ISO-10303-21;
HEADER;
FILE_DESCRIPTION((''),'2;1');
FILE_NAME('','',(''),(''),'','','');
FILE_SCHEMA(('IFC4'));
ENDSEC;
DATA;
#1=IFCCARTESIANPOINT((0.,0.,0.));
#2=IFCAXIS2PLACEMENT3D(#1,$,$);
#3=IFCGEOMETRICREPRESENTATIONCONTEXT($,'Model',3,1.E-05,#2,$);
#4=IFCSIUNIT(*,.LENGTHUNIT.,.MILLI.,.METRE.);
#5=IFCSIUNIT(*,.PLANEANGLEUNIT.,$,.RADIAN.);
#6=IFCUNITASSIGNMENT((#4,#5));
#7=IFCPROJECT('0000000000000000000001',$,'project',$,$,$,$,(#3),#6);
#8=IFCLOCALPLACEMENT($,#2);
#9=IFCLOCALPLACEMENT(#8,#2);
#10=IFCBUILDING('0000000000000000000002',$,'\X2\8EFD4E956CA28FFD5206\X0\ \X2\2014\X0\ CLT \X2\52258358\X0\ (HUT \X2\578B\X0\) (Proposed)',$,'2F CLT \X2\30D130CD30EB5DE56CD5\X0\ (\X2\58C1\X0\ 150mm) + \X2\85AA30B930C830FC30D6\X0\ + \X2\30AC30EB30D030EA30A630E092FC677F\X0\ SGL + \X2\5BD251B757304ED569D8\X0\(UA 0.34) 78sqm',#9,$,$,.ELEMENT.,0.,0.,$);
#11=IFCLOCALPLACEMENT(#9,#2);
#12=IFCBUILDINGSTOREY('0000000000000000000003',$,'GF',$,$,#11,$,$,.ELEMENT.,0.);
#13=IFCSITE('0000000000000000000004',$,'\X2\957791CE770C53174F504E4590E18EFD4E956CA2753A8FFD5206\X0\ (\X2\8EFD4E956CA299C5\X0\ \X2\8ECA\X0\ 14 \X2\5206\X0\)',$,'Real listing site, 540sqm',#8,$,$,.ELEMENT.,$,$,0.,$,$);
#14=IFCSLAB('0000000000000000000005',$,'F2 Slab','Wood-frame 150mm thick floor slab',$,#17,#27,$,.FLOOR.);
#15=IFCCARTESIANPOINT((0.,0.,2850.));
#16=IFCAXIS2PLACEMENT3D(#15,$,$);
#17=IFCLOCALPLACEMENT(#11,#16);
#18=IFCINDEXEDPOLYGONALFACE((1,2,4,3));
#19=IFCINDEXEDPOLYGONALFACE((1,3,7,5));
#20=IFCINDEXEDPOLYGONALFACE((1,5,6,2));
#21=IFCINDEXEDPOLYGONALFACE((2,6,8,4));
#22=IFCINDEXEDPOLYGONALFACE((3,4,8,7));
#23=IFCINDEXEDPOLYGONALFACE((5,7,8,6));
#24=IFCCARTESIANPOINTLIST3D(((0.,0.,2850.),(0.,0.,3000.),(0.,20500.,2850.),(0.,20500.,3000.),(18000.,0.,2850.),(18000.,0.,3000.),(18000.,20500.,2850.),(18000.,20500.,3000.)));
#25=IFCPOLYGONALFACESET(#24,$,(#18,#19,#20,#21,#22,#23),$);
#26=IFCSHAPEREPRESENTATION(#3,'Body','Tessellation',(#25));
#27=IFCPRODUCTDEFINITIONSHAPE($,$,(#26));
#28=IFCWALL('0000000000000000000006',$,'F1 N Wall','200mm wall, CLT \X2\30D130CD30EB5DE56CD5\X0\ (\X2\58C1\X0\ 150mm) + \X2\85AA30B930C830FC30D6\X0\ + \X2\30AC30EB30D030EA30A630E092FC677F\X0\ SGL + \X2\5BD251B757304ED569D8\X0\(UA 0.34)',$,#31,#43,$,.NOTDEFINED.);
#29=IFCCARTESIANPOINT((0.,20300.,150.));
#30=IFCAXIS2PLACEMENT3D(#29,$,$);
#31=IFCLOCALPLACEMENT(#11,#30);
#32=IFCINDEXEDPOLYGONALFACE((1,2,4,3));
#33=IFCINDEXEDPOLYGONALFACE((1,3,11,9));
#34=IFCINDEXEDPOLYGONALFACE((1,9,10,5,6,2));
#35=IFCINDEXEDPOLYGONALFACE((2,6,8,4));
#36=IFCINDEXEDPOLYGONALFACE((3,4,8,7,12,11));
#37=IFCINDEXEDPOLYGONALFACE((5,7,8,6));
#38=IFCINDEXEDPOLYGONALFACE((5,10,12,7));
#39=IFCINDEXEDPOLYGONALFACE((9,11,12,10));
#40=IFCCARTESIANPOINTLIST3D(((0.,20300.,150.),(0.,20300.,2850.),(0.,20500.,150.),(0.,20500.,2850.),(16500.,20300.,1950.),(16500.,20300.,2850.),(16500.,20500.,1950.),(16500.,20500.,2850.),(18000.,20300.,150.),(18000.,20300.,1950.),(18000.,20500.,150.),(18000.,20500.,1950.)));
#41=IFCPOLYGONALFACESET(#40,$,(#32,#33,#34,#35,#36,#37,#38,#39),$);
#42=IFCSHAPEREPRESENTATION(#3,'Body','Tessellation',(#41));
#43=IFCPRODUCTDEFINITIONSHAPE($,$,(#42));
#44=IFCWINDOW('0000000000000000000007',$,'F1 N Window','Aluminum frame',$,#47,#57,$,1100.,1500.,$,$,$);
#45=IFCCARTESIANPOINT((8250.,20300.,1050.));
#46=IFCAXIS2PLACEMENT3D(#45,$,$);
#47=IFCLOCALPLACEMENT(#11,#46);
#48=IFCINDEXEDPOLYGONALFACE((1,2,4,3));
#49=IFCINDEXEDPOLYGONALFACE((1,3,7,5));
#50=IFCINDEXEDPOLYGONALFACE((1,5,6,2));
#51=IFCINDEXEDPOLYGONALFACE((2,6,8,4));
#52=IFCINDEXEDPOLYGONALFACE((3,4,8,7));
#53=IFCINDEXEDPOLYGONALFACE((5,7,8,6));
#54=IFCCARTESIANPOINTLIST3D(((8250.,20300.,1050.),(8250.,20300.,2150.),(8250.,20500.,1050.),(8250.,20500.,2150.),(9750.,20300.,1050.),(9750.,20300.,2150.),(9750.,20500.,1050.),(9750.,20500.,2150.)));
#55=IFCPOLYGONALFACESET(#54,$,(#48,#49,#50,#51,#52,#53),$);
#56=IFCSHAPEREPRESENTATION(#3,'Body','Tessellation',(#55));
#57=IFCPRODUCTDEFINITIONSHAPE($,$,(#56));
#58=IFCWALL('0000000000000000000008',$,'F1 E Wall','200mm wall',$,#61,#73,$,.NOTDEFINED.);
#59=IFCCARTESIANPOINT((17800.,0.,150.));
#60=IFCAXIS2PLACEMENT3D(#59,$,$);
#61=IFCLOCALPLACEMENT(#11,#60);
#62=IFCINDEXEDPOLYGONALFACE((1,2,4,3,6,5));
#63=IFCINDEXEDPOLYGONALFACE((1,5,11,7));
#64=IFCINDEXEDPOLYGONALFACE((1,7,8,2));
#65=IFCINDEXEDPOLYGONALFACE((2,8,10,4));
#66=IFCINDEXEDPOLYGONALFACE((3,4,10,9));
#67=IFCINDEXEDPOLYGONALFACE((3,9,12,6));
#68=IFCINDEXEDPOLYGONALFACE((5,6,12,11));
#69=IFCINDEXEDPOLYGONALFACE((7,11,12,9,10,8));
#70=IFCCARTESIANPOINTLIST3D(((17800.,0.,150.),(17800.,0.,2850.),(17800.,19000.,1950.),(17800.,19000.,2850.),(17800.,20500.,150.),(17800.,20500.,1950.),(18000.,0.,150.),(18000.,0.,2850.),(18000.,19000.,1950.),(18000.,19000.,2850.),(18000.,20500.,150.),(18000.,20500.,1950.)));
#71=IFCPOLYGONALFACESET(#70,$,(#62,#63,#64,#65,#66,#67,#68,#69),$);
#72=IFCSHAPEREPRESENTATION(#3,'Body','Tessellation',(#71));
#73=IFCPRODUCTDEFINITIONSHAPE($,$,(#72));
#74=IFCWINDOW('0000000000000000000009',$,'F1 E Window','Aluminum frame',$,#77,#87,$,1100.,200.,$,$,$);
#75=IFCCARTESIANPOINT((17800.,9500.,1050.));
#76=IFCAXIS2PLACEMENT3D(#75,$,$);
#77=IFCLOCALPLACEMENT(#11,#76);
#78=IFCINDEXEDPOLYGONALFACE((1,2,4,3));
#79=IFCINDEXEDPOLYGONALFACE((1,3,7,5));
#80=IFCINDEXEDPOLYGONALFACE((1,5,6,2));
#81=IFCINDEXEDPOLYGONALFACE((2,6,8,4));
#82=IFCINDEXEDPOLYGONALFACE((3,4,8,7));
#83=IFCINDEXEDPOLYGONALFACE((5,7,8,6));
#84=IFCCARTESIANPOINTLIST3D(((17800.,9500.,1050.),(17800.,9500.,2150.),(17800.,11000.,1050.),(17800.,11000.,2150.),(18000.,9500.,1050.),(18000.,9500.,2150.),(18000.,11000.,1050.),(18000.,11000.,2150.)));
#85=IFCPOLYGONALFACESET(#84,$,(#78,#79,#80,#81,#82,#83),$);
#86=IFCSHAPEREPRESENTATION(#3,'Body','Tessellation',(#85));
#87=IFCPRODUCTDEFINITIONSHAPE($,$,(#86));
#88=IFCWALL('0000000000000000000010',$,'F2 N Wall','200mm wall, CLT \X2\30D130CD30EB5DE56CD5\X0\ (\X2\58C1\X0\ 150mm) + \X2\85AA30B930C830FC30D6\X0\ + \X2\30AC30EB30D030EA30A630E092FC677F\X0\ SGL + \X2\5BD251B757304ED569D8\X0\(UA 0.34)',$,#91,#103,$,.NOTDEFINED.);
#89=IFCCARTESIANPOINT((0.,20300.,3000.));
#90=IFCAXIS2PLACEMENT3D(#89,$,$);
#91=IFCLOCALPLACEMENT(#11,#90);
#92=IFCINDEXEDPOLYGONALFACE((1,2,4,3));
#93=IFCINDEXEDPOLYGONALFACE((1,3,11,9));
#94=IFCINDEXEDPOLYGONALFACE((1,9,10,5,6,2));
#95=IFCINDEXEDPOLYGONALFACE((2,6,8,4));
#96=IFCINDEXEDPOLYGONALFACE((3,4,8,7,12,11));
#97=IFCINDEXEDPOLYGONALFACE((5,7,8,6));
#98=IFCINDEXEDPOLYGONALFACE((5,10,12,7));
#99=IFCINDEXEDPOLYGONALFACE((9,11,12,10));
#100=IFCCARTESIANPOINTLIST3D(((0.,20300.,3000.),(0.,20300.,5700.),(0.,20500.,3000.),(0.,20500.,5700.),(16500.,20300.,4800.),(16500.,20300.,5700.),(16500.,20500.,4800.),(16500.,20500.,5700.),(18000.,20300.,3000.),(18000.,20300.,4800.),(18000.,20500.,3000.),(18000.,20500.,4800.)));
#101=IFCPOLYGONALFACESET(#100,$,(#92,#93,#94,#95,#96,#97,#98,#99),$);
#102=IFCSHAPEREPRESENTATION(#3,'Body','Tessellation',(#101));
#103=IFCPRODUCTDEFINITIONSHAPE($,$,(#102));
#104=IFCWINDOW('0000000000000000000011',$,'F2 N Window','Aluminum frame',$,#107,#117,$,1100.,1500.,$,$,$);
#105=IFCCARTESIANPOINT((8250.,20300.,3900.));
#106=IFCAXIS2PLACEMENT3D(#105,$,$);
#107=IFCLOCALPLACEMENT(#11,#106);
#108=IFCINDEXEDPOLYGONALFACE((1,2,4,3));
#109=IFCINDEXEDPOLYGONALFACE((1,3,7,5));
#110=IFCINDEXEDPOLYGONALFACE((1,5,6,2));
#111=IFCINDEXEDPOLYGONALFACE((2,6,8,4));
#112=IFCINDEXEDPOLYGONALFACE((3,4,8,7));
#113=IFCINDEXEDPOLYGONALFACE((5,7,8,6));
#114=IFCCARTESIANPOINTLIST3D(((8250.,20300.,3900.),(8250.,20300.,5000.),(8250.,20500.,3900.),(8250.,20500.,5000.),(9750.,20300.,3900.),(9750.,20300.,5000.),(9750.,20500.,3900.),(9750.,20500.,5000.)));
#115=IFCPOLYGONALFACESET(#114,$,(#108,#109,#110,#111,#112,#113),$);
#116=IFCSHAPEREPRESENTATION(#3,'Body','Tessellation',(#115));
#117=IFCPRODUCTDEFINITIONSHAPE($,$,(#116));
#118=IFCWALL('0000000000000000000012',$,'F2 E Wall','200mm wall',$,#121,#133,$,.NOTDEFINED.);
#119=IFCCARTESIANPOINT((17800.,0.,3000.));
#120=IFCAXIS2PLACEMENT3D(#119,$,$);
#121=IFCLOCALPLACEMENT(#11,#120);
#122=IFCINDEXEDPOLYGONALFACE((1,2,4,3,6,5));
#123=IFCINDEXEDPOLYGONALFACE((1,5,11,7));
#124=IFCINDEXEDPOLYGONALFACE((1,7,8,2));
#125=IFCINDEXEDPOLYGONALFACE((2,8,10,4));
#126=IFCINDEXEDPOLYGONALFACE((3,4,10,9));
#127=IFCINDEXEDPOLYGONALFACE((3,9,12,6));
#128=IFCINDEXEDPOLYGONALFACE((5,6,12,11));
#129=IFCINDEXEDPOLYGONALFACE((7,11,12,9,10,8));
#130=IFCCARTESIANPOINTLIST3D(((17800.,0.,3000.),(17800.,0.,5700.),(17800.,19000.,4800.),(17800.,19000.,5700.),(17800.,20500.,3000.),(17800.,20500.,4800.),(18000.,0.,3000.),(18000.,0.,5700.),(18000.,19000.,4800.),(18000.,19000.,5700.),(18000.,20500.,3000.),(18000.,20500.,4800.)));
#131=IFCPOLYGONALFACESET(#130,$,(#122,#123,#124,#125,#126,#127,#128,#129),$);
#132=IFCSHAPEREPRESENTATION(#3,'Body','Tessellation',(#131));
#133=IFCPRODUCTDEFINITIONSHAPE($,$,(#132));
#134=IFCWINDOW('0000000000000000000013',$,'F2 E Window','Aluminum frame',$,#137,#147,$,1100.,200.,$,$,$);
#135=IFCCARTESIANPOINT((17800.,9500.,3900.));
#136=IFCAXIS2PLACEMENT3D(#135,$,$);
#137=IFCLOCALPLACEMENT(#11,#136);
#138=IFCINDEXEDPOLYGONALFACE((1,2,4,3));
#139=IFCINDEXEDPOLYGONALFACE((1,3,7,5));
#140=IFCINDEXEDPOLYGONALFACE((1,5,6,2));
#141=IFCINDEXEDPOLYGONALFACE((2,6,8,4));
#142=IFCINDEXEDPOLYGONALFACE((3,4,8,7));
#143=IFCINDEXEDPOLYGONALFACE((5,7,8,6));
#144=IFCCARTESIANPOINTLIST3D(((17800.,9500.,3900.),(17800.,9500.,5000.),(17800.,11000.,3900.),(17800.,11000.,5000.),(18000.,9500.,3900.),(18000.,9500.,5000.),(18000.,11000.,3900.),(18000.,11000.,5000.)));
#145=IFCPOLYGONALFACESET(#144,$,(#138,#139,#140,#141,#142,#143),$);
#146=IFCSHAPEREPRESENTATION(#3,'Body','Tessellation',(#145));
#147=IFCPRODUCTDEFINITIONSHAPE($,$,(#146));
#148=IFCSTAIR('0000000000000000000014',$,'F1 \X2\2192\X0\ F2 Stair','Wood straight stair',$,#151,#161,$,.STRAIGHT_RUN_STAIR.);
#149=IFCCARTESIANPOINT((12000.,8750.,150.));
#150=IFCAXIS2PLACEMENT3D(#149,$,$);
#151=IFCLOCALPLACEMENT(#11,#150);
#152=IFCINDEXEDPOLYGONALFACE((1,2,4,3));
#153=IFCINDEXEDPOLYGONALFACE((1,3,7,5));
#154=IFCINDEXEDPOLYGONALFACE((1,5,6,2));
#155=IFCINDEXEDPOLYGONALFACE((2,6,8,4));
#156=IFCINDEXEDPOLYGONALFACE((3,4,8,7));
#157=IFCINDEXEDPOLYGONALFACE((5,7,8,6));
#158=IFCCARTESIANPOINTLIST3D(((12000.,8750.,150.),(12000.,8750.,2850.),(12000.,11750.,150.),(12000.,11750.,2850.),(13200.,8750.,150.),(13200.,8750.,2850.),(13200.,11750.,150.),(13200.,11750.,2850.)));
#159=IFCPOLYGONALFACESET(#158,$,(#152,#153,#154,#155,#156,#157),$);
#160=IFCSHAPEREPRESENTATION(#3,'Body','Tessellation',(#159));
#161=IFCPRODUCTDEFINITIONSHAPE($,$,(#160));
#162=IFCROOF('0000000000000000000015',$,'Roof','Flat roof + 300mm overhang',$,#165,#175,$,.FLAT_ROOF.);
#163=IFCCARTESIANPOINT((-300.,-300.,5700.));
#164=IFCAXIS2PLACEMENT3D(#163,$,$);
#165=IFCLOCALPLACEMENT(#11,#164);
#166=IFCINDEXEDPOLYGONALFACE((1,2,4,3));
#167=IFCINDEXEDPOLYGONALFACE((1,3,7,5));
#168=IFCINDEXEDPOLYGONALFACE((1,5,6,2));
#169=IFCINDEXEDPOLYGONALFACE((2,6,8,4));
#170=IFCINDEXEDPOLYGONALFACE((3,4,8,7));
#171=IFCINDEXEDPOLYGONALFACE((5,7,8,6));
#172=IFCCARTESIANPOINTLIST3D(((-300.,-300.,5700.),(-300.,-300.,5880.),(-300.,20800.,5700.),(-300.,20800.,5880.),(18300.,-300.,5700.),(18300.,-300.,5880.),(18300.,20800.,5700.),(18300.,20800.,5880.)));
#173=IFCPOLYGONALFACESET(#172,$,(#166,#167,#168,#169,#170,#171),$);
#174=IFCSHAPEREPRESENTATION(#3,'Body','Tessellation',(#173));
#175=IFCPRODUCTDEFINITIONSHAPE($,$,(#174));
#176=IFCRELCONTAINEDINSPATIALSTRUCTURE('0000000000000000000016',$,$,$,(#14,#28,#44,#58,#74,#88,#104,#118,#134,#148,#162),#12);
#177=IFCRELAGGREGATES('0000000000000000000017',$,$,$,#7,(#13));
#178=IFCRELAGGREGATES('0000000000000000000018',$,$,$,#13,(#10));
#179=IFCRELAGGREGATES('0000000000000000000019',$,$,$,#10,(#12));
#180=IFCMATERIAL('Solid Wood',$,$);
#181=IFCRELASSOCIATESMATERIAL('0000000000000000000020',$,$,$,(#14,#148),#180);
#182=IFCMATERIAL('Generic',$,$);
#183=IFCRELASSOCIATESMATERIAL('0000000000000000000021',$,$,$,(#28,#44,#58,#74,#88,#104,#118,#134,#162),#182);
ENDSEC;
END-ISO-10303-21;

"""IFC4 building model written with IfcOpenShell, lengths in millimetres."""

from ifc_helpers import new_model, si_unit, frame, frame_2d, origin, place, context, project, spatial, rectangle, extrude, material, element, fill, save


model = new_model("IFC4")

# Units and contexts
model_context = context("Model", 3, precision=1e-05, world=origin())
ifc_project = project(units=[si_unit("LENGTHUNIT", "METRE", prefix="MILLI"), si_unit("PLANEANGLEUNIT", "RADIAN")], contexts=[model_context])

# Site, building, storey
site_placement = place(None, origin())
site = spatial("IfcSite", under=ifc_project, at=site_placement, Name="長野県北佐久郡軽井沢町追分 (軽井沢駅 車 14 分)", ObjectType="Real listing site, 540sqm", CompositionType="ELEMENT", RefElevation=0.0)
building_placement = place(site_placement, origin())
building = spatial("IfcBuilding", under=site, at=building_placement, Name="軽井沢追分 — CLT 別荘 (HUT 型) (Proposed)", ObjectType="2F CLT パネル工法 (壁 150mm) + 薪ストーブ + ガルバリウム鋼板 SGL + 寒冷地仕様(UA 0.34) 78sqm", CompositionType="ELEMENT", ElevationOfRefHeight=0.0, ElevationOfTerrain=0.0)
storey_placement = place(building_placement, origin())
storey = spatial("IfcBuildingStorey", under=building, at=storey_placement, Name="GF", CompositionType="ELEMENT", Elevation=0.0)

# Slab
ifc_material_1 = material(Name="Solid Wood")
slab_1_placement = place(storey_placement, frame((0.0, 0.0, 2850.0)))
element("IfcSlab", 1, at=slab_1_placement, inside=storey, material=ifc_material_1, Name="F2 Slab", Description="Wood-frame 150mm thick floor slab", PredefinedType="FLOOR", context=model_context, shape_type="SweptSolid", body=[
    extrude(rectangle(XDim=18000.0, YDim=20500.0, at=frame_2d((9000.0, 10250.0))), frame((0.0, 0.0, 2850.0)), (0.0, 0.0, 1.0), 150.0),
])

# Wall, opening, window
ifc_material_2 = material(Name="Generic")
wall_1_placement = place(storey_placement, frame((0.0, 20300.0, 150.0)))
wall_1 = element("IfcWall", 2, at=wall_1_placement, inside=storey, material=ifc_material_2, Name="F1 N Wall", Description="200mm wall, CLT パネル工法 (壁 150mm) + 薪ストーブ + ガルバリウム鋼板 SGL + 寒冷地仕様(UA 0.34)", PredefinedType="NOTDEFINED", context=model_context, shape_type="SweptSolid", body=[
    extrude(rectangle(XDim=18000.0, YDim=200.0, at=frame_2d((9000.0, 100.0))), frame((0.0, 20300.0, 150.0)), (0.0, 0.0, 1.0), 2700.0),
])
opening_1_placement = place(storey_placement, frame((8250.0, 20300.0, 1050.0)))
opening_1 = element("IfcOpeningElement", 3, at=opening_1_placement, cuts=wall_1, PredefinedType="NOTDEFINED", context=model_context, shape_type="SweptSolid", body=[
    extrude(rectangle(XDim=1500.0, YDim=200.0, at=frame_2d((750.0, 100.0))), frame((8250.0, 20300.0, 1050.0)), (0.0, 0.0, 1.0), 1100.0),
])
window_1_placement = place(storey_placement, frame((8250.0, 20300.0, 1050.0)))
window_1 = element("IfcWindow", 4, at=window_1_placement, inside=storey, material=ifc_material_2, Name="F1 N Window", Description="Aluminum frame", OverallHeight=1100.0, OverallWidth=1500.0, context=model_context, shape_type="SweptSolid", body=[
    extrude(rectangle(XDim=1500.0, YDim=200.0, at=frame_2d((750.0, 100.0))), frame((8250.0, 20300.0, 1050.0)), (0.0, 0.0, 1.0), 1100.0),
])
fill(opening_1, window_1)

# Walls, openings, windows
wall_2_placement = place(storey_placement, frame((17800.0, 0.0, 150.0)))
wall_2 = element("IfcWall", 5, at=wall_2_placement, inside=storey, material=ifc_material_2, Name="F1 E Wall", Description="200mm wall", PredefinedType="NOTDEFINED", context=model_context, shape_type="SweptSolid", body=[
    extrude(rectangle(XDim=200.0, YDim=20500.0, at=frame_2d((100.0, 10250.0))), frame((17800.0, 0.0, 150.0)), (0.0, 0.0, 1.0), 2700.0),
])
opening_2_placement = place(storey_placement, frame((17800.0, 9500.0, 1050.0)))
opening_2 = element("IfcOpeningElement", 6, at=opening_2_placement, cuts=wall_2, PredefinedType="NOTDEFINED", context=model_context, shape_type="SweptSolid", body=[
    extrude(rectangle(XDim=200.0, YDim=1500.0, at=frame_2d((100.0, 750.0))), frame((17800.0, 9500.0, 1050.0)), (0.0, 0.0, 1.0), 1100.0),
])
window_2_placement = place(storey_placement, frame((17800.0, 9500.0, 1050.0)))
window_2 = element("IfcWindow", 7, at=window_2_placement, inside=storey, material=ifc_material_2, Name="F1 E Window", Description="Aluminum frame", OverallHeight=1100.0, OverallWidth=200.0, context=model_context, shape_type="SweptSolid", body=[
    extrude(rectangle(XDim=200.0, YDim=1500.0, at=frame_2d((100.0, 750.0))), frame((17800.0, 9500.0, 1050.0)), (0.0, 0.0, 1.0), 1100.0),
])
fill(opening_2, window_2)
wall_3_placement = place(storey_placement, frame((0.0, 20300.0, 3000.0)))
wall_3 = element("IfcWall", 8, at=wall_3_placement, inside=storey, material=ifc_material_2, Name="F2 N Wall", Description="200mm wall, CLT パネル工法 (壁 150mm) + 薪ストーブ + ガルバリウム鋼板 SGL + 寒冷地仕様(UA 0.34)", PredefinedType="NOTDEFINED", context=model_context, shape_type="SweptSolid", body=[
    extrude(rectangle(XDim=18000.0, YDim=200.0, at=frame_2d((9000.0, 100.0))), frame((0.0, 20300.0, 3000.0)), (0.0, 0.0, 1.0), 2700.0),
])
opening_3_placement = place(storey_placement, frame((8250.0, 20300.0, 3900.0)))
opening_3 = element("IfcOpeningElement", 9, at=opening_3_placement, cuts=wall_3, PredefinedType="NOTDEFINED", context=model_context, shape_type="SweptSolid", body=[
    extrude(rectangle(XDim=1500.0, YDim=200.0, at=frame_2d((750.0, 100.0))), frame((8250.0, 20300.0, 3900.0)), (0.0, 0.0, 1.0), 1100.0),
])
window_3_placement = place(storey_placement, frame((8250.0, 20300.0, 3900.0)))
window_3 = element("IfcWindow", 10, at=window_3_placement, inside=storey, material=ifc_material_2, Name="F2 N Window", Description="Aluminum frame", OverallHeight=1100.0, OverallWidth=1500.0, context=model_context, shape_type="SweptSolid", body=[
    extrude(rectangle(XDim=1500.0, YDim=200.0, at=frame_2d((750.0, 100.0))), frame((8250.0, 20300.0, 3900.0)), (0.0, 0.0, 1.0), 1100.0),
])
fill(opening_3, window_3)
wall_4_placement = place(storey_placement, frame((17800.0, 0.0, 3000.0)))
wall_4 = element("IfcWall", 11, at=wall_4_placement, inside=storey, material=ifc_material_2, Name="F2 E Wall", Description="200mm wall", PredefinedType="NOTDEFINED", context=model_context, shape_type="SweptSolid", body=[
    extrude(rectangle(XDim=200.0, YDim=20500.0, at=frame_2d((100.0, 10250.0))), frame((17800.0, 0.0, 3000.0)), (0.0, 0.0, 1.0), 2700.0),
])
opening_4_placement = place(storey_placement, frame((17800.0, 9500.0, 3900.0)))
opening_4 = element("IfcOpeningElement", 12, at=opening_4_placement, cuts=wall_4, PredefinedType="NOTDEFINED", context=model_context, shape_type="SweptSolid", body=[
    extrude(rectangle(XDim=200.0, YDim=1500.0, at=frame_2d((100.0, 750.0))), frame((17800.0, 9500.0, 3900.0)), (0.0, 0.0, 1.0), 1100.0),
])
window_4_placement = place(storey_placement, frame((17800.0, 9500.0, 3900.0)))
window_4 = element("IfcWindow", 13, at=window_4_placement, inside=storey, material=ifc_material_2, Name="F2 E Window", Description="Aluminum frame", OverallHeight=1100.0, OverallWidth=200.0, context=model_context, shape_type="SweptSolid", body=[
    extrude(rectangle(XDim=200.0, YDim=1500.0, at=frame_2d((100.0, 750.0))), frame((17800.0, 9500.0, 3900.0)), (0.0, 0.0, 1.0), 1100.0),
])
fill(opening_4, window_4)

# Stair
stair_placement = place(storey_placement, frame((12000.0, 8750.0, 150.0)))
element("IfcStair", 14, at=stair_placement, inside=storey, material=ifc_material_1, Name="F1 → F2 Stair", Description="Wood straight stair", PredefinedType="STRAIGHT_RUN_STAIR", context=model_context, shape_type="SweptSolid", body=[
    extrude(rectangle(XDim=1200.0, YDim=3000.0, at=frame_2d((600.0, 1500.0))), frame((12000.0, 8750.0, 150.0)), (0.0, 0.0, 1.0), 2700.0),
])

# Roof
roof_placement = place(storey_placement, frame((-300.0, -300.0, 5700.0)))
element("IfcRoof", 15, at=roof_placement, inside=storey, material=ifc_material_2, Name="Roof", Description="Flat roof + 300mm overhang", PredefinedType="FLAT_ROOF", context=model_context, shape_type="SweptSolid", body=[
    extrude(rectangle(XDim=18600.0, YDim=21100.0, at=frame_2d((9300.0, 10550.0))), frame((-300.0, -300.0, 5700.0)), (0.0, 0.0, 1.0), 180.0),
])

save(model, "model.ifc")
